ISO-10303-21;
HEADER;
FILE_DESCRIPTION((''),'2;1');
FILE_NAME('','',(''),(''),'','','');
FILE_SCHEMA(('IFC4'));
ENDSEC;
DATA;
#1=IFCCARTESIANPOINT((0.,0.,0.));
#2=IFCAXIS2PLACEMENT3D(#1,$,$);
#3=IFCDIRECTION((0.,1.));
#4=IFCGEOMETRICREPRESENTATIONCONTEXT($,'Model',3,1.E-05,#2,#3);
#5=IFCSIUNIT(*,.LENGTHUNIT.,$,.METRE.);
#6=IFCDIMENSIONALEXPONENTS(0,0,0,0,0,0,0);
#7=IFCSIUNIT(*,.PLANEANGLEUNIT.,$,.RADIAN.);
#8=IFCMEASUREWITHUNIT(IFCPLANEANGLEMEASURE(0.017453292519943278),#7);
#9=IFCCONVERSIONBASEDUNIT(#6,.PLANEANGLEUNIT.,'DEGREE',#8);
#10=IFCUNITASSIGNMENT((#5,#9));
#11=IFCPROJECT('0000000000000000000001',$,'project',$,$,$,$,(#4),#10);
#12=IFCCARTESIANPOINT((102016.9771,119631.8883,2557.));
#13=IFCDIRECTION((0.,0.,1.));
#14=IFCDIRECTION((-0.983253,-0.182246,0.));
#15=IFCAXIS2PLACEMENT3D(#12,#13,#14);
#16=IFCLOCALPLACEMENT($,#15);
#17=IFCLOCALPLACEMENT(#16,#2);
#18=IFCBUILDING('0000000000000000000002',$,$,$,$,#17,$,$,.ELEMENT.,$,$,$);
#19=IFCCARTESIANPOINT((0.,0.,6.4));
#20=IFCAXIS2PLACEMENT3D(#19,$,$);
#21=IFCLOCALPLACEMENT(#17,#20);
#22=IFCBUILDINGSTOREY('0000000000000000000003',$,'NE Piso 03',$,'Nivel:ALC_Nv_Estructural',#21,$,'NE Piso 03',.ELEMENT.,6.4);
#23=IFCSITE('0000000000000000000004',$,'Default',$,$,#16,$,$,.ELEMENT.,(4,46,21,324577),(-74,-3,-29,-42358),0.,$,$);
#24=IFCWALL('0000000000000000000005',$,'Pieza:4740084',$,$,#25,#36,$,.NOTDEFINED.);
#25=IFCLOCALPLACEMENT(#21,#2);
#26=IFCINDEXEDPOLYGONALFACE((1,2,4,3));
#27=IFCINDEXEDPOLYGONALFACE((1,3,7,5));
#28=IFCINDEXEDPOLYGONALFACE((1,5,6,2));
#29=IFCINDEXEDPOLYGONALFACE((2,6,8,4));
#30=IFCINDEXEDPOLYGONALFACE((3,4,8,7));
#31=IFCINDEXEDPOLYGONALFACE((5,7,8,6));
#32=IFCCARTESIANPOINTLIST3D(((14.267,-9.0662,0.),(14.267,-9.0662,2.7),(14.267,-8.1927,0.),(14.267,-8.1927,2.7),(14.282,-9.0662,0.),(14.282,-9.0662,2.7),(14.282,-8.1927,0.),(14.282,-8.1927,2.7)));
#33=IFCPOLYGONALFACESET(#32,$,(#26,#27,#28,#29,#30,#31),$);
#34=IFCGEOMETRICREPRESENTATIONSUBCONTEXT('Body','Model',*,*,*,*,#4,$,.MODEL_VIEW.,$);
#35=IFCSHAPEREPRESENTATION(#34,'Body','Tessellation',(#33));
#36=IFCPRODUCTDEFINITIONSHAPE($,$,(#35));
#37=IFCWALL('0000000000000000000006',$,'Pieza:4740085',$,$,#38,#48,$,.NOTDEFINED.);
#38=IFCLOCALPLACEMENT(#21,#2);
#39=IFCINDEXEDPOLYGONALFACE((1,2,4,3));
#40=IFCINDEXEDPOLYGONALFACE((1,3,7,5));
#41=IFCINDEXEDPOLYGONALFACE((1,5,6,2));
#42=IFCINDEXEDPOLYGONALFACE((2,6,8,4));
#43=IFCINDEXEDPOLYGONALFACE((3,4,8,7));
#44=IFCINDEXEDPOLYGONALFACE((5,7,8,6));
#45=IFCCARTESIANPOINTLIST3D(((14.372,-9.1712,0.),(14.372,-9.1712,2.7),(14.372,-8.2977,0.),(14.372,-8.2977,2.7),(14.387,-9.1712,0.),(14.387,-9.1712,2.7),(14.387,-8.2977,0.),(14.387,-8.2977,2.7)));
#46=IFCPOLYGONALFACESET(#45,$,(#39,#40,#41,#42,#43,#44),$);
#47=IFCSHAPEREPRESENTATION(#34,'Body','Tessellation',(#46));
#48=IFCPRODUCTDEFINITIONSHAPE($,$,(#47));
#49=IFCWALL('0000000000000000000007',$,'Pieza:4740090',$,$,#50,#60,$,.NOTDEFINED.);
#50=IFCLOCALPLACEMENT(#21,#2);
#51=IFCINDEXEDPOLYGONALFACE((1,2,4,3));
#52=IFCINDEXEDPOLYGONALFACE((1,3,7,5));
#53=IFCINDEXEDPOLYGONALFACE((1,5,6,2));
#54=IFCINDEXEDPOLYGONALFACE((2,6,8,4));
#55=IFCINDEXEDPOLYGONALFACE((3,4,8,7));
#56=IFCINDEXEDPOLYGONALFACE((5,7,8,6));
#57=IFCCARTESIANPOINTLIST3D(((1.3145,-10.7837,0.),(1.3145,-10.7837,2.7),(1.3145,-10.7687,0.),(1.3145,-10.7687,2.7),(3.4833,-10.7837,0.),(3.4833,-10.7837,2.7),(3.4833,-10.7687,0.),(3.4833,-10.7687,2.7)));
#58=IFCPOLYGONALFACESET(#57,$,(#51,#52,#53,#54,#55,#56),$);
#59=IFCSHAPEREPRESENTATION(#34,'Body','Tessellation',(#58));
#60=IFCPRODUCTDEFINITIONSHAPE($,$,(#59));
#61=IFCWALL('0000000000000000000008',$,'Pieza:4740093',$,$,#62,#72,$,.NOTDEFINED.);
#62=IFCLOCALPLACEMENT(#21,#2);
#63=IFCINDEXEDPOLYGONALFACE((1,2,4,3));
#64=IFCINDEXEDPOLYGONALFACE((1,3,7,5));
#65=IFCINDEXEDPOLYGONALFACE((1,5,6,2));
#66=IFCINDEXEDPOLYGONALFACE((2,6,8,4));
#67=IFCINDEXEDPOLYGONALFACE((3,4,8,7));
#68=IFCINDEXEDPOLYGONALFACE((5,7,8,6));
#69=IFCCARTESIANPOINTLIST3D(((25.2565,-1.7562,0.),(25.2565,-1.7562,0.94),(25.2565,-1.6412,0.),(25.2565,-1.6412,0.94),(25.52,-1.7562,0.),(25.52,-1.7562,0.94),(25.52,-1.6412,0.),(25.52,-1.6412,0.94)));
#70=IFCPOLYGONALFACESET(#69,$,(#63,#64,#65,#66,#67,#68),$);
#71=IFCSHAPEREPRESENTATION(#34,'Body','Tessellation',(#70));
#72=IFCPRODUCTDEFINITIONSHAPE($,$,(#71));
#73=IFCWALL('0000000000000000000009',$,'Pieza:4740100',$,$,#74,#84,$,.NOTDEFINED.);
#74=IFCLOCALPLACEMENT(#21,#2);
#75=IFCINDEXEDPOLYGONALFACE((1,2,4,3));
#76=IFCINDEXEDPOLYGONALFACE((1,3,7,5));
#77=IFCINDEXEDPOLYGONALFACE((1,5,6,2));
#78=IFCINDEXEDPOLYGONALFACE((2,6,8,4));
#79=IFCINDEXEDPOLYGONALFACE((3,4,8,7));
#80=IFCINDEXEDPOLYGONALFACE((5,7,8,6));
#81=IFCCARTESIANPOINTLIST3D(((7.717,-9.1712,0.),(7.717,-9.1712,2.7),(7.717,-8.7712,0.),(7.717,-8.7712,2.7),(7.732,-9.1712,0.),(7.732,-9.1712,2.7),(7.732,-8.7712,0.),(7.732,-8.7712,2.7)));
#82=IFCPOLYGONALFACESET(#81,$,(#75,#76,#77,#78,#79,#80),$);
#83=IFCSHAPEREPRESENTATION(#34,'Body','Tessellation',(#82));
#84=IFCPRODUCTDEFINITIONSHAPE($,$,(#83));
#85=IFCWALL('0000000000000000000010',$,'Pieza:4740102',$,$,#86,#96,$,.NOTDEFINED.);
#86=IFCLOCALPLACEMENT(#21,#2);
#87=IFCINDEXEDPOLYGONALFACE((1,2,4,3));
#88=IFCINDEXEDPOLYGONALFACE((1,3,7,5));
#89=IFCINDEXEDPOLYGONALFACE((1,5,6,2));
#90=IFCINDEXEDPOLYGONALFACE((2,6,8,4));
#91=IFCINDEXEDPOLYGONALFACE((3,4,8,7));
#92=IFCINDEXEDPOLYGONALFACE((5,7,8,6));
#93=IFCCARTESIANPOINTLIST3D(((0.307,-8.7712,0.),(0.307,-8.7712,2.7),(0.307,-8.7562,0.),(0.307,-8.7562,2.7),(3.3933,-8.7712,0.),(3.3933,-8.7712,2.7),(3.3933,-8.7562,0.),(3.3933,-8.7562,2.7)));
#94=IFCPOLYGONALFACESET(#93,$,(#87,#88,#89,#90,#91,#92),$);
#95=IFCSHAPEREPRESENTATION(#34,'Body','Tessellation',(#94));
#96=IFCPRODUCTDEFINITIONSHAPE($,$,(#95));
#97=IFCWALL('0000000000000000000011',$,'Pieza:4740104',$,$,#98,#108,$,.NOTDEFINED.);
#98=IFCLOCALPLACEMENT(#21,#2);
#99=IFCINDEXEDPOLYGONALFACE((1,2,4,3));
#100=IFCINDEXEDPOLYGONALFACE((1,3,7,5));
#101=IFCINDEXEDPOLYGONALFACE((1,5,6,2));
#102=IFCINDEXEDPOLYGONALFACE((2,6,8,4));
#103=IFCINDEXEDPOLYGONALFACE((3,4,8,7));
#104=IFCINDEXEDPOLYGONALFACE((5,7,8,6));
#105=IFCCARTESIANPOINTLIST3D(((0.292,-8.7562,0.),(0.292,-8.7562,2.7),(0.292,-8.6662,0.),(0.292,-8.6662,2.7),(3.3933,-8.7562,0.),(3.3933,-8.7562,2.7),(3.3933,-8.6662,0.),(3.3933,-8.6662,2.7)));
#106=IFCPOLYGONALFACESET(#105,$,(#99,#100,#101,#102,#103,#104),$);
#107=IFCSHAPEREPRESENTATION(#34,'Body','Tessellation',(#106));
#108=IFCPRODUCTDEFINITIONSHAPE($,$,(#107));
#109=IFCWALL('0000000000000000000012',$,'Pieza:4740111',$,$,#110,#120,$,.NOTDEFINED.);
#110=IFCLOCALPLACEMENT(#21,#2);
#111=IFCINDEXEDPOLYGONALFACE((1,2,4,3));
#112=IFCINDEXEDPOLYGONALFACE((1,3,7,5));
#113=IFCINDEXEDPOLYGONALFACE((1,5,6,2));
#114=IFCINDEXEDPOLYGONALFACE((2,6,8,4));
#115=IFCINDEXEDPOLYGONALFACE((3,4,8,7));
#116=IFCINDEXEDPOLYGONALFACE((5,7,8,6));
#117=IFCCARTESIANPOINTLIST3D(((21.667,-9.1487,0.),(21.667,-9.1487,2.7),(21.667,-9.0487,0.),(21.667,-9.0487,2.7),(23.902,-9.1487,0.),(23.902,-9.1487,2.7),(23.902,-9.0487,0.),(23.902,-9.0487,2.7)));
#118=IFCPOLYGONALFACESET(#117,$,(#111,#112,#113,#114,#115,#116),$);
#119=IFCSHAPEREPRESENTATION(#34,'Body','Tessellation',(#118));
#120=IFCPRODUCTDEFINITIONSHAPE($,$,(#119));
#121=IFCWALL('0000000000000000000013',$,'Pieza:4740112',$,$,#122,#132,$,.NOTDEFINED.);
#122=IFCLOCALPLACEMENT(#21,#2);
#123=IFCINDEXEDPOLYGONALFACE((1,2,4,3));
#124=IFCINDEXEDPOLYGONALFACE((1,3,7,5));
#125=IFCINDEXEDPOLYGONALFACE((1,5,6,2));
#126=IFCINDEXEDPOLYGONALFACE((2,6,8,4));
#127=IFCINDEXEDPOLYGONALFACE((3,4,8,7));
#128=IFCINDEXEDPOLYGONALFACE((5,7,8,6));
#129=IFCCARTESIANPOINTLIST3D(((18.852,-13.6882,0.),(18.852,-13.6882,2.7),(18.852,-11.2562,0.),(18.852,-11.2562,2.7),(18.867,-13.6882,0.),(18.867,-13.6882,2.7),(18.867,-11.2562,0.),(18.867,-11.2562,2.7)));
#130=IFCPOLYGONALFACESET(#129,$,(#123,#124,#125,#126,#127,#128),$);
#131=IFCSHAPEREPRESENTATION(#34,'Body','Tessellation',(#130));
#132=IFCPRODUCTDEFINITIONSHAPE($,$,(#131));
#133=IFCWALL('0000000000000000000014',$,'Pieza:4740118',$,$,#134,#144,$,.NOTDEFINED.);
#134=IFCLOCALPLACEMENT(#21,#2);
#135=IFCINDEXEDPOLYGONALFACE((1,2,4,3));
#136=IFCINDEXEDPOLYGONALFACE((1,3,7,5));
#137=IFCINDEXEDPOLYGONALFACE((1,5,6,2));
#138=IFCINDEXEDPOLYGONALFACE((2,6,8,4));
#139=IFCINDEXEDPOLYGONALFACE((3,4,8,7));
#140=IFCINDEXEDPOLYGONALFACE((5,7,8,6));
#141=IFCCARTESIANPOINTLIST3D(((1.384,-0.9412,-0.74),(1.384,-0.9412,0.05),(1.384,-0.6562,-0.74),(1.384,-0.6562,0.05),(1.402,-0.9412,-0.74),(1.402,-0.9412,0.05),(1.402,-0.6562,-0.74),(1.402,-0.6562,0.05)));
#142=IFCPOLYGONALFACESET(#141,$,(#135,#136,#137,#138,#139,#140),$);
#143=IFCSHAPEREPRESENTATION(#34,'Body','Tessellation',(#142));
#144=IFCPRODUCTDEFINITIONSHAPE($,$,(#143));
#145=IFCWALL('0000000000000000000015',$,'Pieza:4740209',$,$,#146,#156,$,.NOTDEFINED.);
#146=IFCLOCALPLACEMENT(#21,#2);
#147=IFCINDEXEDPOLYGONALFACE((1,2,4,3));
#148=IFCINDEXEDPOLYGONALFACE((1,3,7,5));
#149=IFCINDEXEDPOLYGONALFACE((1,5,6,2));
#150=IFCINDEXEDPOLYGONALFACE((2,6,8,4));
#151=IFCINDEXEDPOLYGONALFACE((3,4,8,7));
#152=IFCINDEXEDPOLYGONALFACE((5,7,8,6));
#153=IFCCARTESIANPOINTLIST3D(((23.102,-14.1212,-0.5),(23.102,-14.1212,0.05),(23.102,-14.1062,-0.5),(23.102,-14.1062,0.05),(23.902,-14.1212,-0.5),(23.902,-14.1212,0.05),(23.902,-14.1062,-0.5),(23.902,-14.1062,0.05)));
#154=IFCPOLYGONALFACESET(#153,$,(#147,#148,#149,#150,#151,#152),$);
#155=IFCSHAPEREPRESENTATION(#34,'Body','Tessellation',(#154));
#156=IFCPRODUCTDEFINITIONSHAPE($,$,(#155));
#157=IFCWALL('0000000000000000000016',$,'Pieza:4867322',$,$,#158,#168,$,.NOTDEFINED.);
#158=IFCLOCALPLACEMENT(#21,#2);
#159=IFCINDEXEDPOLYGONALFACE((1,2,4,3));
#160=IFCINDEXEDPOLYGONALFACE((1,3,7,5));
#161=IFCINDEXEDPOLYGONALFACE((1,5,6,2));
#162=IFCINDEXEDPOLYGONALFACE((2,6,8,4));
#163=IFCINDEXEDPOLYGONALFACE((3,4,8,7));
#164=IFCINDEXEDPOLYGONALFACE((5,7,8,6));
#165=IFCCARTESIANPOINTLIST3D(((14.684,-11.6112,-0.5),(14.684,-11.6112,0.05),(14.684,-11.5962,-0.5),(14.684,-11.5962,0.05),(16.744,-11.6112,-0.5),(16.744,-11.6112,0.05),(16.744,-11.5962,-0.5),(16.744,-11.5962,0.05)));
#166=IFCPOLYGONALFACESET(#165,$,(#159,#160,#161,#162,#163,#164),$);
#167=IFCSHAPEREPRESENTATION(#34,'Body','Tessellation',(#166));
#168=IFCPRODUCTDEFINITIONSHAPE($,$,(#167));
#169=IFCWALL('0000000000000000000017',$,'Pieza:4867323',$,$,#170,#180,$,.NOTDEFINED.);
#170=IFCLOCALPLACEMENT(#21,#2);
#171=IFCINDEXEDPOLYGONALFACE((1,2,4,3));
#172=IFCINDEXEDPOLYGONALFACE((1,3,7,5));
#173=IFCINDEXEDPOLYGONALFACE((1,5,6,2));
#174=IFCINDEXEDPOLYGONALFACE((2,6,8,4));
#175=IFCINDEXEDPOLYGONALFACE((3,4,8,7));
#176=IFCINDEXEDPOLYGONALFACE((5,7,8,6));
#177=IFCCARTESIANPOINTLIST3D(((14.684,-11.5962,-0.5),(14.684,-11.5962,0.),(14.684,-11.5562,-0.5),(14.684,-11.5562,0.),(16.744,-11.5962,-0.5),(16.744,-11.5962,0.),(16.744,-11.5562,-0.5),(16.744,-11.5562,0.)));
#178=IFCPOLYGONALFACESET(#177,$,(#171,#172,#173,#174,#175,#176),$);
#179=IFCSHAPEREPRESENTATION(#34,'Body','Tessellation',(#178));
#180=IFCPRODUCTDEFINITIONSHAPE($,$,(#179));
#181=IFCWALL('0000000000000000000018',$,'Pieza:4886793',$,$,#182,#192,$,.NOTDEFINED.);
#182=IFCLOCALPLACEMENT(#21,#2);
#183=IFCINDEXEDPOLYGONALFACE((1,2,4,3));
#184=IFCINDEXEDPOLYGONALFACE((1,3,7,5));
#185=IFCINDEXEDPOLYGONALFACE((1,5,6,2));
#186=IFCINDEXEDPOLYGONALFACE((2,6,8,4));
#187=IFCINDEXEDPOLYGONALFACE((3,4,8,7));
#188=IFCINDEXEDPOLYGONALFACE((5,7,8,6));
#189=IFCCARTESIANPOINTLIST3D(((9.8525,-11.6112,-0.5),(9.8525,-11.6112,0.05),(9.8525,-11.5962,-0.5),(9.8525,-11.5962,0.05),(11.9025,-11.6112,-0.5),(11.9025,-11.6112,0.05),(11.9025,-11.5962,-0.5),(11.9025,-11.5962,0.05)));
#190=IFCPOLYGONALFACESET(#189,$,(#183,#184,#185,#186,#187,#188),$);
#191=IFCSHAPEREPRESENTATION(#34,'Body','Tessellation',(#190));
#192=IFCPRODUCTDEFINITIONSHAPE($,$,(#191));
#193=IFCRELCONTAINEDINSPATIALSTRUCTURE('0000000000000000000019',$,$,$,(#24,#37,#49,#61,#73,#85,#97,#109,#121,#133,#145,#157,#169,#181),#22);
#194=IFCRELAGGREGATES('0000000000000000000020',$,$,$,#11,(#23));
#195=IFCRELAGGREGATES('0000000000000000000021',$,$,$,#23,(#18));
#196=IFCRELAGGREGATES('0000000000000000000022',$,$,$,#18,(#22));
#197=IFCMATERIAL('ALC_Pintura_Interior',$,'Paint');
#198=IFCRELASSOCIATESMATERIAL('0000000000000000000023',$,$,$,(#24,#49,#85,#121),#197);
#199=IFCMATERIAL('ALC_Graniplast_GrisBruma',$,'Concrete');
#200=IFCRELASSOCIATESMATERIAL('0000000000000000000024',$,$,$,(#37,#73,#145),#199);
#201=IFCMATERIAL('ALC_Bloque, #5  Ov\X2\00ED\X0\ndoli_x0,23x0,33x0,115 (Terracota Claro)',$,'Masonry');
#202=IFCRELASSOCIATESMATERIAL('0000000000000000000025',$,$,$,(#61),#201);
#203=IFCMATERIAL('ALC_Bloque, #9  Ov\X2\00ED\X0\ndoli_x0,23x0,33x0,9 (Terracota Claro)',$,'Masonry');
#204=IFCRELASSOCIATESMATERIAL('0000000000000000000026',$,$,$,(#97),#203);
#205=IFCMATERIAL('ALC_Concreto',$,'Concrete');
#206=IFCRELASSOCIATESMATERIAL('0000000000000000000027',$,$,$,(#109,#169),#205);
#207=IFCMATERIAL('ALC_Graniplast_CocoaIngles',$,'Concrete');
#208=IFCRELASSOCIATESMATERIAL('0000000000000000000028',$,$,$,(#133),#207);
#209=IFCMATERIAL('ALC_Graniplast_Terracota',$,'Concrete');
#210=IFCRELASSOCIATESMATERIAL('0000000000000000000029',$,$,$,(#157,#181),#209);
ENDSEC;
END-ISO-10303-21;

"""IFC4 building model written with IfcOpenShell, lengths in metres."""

from ifc_helpers import new_model, entity, si_unit, converted_unit, direction, frame, frame_2d, origin, origin_2d_with_axis, place, context, subcontext, project, spatial, rectangle, extrude, material, element, save


model = new_model("IFC4")

# Units and contexts
model_context = context("Model", 3, precision=1e-05, world=origin(), true_north=direction((0.0, 1.0)))
body_context = subcontext(model_context, "Body", "Model", "MODEL_VIEW")
ifc_project = project(units=[si_unit("LENGTHUNIT", "METRE"), converted_unit("PLANEANGLEUNIT", "DEGREE", entity("IfcPlaneAngleMeasure", 0.017453292519943278), si_unit("PLANEANGLEUNIT", "RADIAN"), dimensions=[0, 0, 0, 0, 0, 0, 0])], contexts=[model_context])

# Site, building, storey
site_placement = place(None, frame((102016.9771, 119631.8883, 2557.0), z_axis=(0.0, 0.0, 1.0), x_axis=(-0.983253, -0.182246, 0.0)))
site = spatial("IfcSite", under=ifc_project, at=site_placement, Name="Default", CompositionType="ELEMENT", RefLatitude=(4, 46, 21, 324577), RefLongitude=(-74, -3, -29, -42358), RefElevation=0.0)
building_placement = place(site_placement, origin())
building = spatial("IfcBuilding", under=site, at=building_placement, CompositionType="ELEMENT")
storey_placement = place(building_placement, frame((0.0, 0.0, 6.4)))
storey = spatial("IfcBuildingStorey", under=building, at=storey_placement, Name="NE Piso 03", ObjectType="Nivel:ALC_Nv_Estructural", LongName="NE Piso 03", CompositionType="ELEMENT", Elevation=6.4)

# Walls
ifc_material_1 = material(Name="ALC_Pintura_Interior", Category="Paint")
wall_1_placement = place(storey_placement, origin())
element("IfcWall", 1, at=wall_1_placement, inside=storey, material=ifc_material_1, Name="Pieza:4740084", PredefinedType="NOTDEFINED", context=body_context, shape_type="SweptSolid", body=[
    extrude(rectangle(XDim=0.8735, YDim=0.015, at=frame_2d((0.0, 0.0), x_axis=(1.0, 0.0))), frame((14.2745, -8.6294, 0.0), z_axis=(0.0, 0.0, 1.0), x_axis=(0.0, -1.0, 0.0)), (0.0, 0.0, 1.0), 2.7),
])
ifc_material_2 = material(Name="ALC_Graniplast_GrisBruma", Category="Concrete")
wall_2_placement = place(storey_placement, origin())
element("IfcWall", 2, at=wall_2_placement, inside=storey, material=ifc_material_2, Name="Pieza:4740085", PredefinedType="NOTDEFINED", context=body_context, shape_type="SweptSolid", body=[
    extrude(rectangle(XDim=0.8735, YDim=0.015, at=frame_2d((0.0, 0.0), x_axis=(1.0, 0.0))), frame((14.3795, -8.7344, 0.0), z_axis=(0.0, 0.0, 1.0), x_axis=(0.0, -1.0, 0.0)), (0.0, 0.0, 1.0), 2.7),
])
wall_3_placement = place(storey_placement, origin())
element("IfcWall", 3, at=wall_3_placement, inside=storey, material=ifc_material_1, Name="Pieza:4740090", PredefinedType="NOTDEFINED", context=body_context, shape_type="SweptSolid", body=[
    extrude(rectangle(XDim=0.015, YDim=2.1688, at=frame_2d((0.0, 0.0), x_axis=(1.0, 0.0))), frame((2.3989, -10.7762, 0.0), z_axis=(0.0, 0.0, 1.0), x_axis=(0.0, -1.0, 0.0)), (0.0, 0.0, 1.0), 2.7),
])
ifc_material_3 = material(Name="ALC_Bloque, #5  Ovíndoli_x0,23x0,33x0,115 (Terracota Claro)", Category="Masonry")
wall_4_placement = place(storey_placement, origin())
element("IfcWall", 4, at=wall_4_placement, inside=storey, material=ifc_material_3, Name="Pieza:4740093", PredefinedType="NOTDEFINED", context=body_context, shape_type="SweptSolid", body=[
    extrude(rectangle(XDim=0.115, YDim=0.2635, at=origin_2d_with_axis()), frame((25.3883, -1.6987, 0.0), z_axis=(0.0, 0.0, 1.0), x_axis=(0.0, -1.0, 0.0)), (0.0, 0.0, 1.0), 0.94),
])
wall_5_placement = place(storey_placement, origin())
element("IfcWall", 5, at=wall_5_placement, inside=storey, material=ifc_material_2, Name="Pieza:4740100", PredefinedType="NOTDEFINED", context=body_context, shape_type="SweptSolid", body=[
    extrude(rectangle(XDim=0.4, YDim=0.015, at=origin_2d_with_axis()), frame((7.7245, -8.9712, 0.0), z_axis=(0.0, 0.0, 1.0), x_axis=(0.0, -1.0, 0.0)), (0.0, 0.0, 1.0), 2.7),
])
wall_6_placement = place(storey_placement, origin())
element("IfcWall", 6, at=wall_6_placement, inside=storey, material=ifc_material_1, Name="Pieza:4740102", PredefinedType="NOTDEFINED", context=body_context, shape_type="SweptSolid", body=[
    extrude(rectangle(XDim=0.015, YDim=3.0863, at=origin_2d_with_axis()), frame((1.8502, -8.7637, 0.0), z_axis=(0.0, 0.0, 1.0), x_axis=(0.0, -1.0, 0.0)), (0.0, 0.0, 1.0), 2.7),
])
ifc_material_4 = material(Name="ALC_Bloque, #9  Ovíndoli_x0,23x0,33x0,9 (Terracota Claro)", Category="Masonry")
wall_7_placement = place(storey_placement, origin())
element("IfcWall", 7, at=wall_7_placement, inside=storey, material=ifc_material_4, Name="Pieza:4740104", PredefinedType="NOTDEFINED", context=body_context, shape_type="SweptSolid", body=[
    extrude(rectangle(XDim=0.09, YDim=3.1013, at=origin_2d_with_axis()), frame((1.8427, -8.7112, 0.0), z_axis=(0.0, 0.0, 1.0), x_axis=(0.0, -1.0, 0.0)), (0.0, 0.0, 1.0), 2.7),
])
ifc_material_5 = material(Name="ALC_Concreto", Category="Concrete")
wall_8_placement = place(storey_placement, origin())
element("IfcWall", 8, at=wall_8_placement, inside=storey, material=ifc_material_5, Name="Pieza:4740111", PredefinedType="NOTDEFINED", context=body_context, shape_type="SweptSolid", body=[
    extrude(rectangle(XDim=0.1, YDim=2.235, at=frame_2d((0.0, 0.0), x_axis=(1.0, 0.0))), frame((22.7845, -9.0987, 0.0), z_axis=(0.0, 0.0, 1.0), x_axis=(0.0, -1.0, 0.0)), (0.0, 0.0, 1.0), 2.7),
])
wall_9_placement = place(storey_placement, origin())
element("IfcWall", 9, at=wall_9_placement, inside=storey, material=ifc_material_1, Name="Pieza:4740112", PredefinedType="NOTDEFINED", context=body_context, shape_type="SweptSolid", body=[
    extrude(rectangle(XDim=2.432, YDim=0.015, at=frame_2d((0.0, 0.0), x_axis=(1.0, 0.0))), frame((18.8595, -12.4722, 0.0), z_axis=(0.0, 0.0, 1.0), x_axis=(0.0, -1.0, 0.0)), (0.0, 0.0, 1.0), 2.7),
])
ifc_material_6 = material(Name="ALC_Graniplast_CocoaIngles", Category="Concrete")
wall_10_placement = place(storey_placement, frame((0.0, 0.0, -0.74)))
element("IfcWall", 10, at=wall_10_placement, inside=storey, material=ifc_material_6, Name="Pieza:4740118", PredefinedType="NOTDEFINED", context=body_context, shape_type="SweptSolid", body=[
    extrude(rectangle(XDim=0.285, YDim=0.018, at=frame_2d((0.0, 0.0), x_axis=(1.0, 0.0))), frame((1.393, -0.7987, 0.0), z_axis=(0.0, 0.0, 1.0), x_axis=(0.0, -1.0, 0.0)), (0.0, 0.0, 1.0), 0.79),
])
wall_11_placement = place(storey_placement, frame((0.0, 0.0, -0.5)))
element("IfcWall", 11, at=wall_11_placement, inside=storey, material=ifc_material_2, Name="Pieza:4740209", PredefinedType="NOTDEFINED", context=body_context, shape_type="SweptSolid", body=[
    extrude(rectangle(XDim=0.015, YDim=0.8, at=frame_2d((0.0, 0.0), x_axis=(1.0, 0.0))), frame((23.502, -14.1137, 0.0), z_axis=(0.0, 0.0, 1.0), x_axis=(0.0, -1.0, 0.0)), (0.0, 0.0, 1.0), 0.55),
])
ifc_material_7 = material(Name="ALC_Graniplast_Terracota", Category="Concrete")
wall_12_placement = place(storey_placement, frame((0.0, 0.0, -0.5)))
element("IfcWall", 12, at=wall_12_placement, inside=storey, material=ifc_material_7, Name="Pieza:4867322", PredefinedType="NOTDEFINED", context=body_context, shape_type="SweptSolid", body=[
    extrude(rectangle(XDim=0.015, YDim=2.06, at=frame_2d((0.0, 0.0), x_axis=(1.0, 0.0))), frame((15.714, -11.6037, 0.0), z_axis=(0.0, 0.0, 1.0), x_axis=(0.0, -1.0, 0.0)), (0.0, 0.0, 1.0), 0.55),
])
wall_13_placement = place(storey_placement, frame((0.0, 0.0, -0.5)))
element("IfcWall", 13, at=wall_13_placement, inside=storey, material=ifc_material_5, Name="Pieza:4867323", PredefinedType="NOTDEFINED", context=body_context, shape_type="SweptSolid", body=[
    extrude(rectangle(XDim=0.04, YDim=2.06, at=frame_2d((0.0, 0.0), x_axis=(1.0, 0.0))), frame((15.714, -11.5762, 0.0), z_axis=(0.0, 0.0, 1.0), x_axis=(0.0, -1.0, 0.0)), (0.0, 0.0, 1.0), 0.5),
])
wall_14_placement = place(storey_placement, frame((0.0, 0.0, -0.5)))
element("IfcWall", 14, at=wall_14_placement, inside=storey, material=ifc_material_7, Name="Pieza:4886793", PredefinedType="NOTDEFINED", context=body_context, shape_type="SweptSolid", body=[
    extrude(rectangle(XDim=0.015, YDim=2.05, at=frame_2d((0.0, 0.0), x_axis=(1.0, 0.0))), frame((10.8775, -11.6037, 0.0), z_axis=(0.0, 0.0, 1.0), x_axis=(0.0, -1.0, 0.0)), (0.0, 0.0, 1.0), 0.55),
])

save(model, "model.ifc")
